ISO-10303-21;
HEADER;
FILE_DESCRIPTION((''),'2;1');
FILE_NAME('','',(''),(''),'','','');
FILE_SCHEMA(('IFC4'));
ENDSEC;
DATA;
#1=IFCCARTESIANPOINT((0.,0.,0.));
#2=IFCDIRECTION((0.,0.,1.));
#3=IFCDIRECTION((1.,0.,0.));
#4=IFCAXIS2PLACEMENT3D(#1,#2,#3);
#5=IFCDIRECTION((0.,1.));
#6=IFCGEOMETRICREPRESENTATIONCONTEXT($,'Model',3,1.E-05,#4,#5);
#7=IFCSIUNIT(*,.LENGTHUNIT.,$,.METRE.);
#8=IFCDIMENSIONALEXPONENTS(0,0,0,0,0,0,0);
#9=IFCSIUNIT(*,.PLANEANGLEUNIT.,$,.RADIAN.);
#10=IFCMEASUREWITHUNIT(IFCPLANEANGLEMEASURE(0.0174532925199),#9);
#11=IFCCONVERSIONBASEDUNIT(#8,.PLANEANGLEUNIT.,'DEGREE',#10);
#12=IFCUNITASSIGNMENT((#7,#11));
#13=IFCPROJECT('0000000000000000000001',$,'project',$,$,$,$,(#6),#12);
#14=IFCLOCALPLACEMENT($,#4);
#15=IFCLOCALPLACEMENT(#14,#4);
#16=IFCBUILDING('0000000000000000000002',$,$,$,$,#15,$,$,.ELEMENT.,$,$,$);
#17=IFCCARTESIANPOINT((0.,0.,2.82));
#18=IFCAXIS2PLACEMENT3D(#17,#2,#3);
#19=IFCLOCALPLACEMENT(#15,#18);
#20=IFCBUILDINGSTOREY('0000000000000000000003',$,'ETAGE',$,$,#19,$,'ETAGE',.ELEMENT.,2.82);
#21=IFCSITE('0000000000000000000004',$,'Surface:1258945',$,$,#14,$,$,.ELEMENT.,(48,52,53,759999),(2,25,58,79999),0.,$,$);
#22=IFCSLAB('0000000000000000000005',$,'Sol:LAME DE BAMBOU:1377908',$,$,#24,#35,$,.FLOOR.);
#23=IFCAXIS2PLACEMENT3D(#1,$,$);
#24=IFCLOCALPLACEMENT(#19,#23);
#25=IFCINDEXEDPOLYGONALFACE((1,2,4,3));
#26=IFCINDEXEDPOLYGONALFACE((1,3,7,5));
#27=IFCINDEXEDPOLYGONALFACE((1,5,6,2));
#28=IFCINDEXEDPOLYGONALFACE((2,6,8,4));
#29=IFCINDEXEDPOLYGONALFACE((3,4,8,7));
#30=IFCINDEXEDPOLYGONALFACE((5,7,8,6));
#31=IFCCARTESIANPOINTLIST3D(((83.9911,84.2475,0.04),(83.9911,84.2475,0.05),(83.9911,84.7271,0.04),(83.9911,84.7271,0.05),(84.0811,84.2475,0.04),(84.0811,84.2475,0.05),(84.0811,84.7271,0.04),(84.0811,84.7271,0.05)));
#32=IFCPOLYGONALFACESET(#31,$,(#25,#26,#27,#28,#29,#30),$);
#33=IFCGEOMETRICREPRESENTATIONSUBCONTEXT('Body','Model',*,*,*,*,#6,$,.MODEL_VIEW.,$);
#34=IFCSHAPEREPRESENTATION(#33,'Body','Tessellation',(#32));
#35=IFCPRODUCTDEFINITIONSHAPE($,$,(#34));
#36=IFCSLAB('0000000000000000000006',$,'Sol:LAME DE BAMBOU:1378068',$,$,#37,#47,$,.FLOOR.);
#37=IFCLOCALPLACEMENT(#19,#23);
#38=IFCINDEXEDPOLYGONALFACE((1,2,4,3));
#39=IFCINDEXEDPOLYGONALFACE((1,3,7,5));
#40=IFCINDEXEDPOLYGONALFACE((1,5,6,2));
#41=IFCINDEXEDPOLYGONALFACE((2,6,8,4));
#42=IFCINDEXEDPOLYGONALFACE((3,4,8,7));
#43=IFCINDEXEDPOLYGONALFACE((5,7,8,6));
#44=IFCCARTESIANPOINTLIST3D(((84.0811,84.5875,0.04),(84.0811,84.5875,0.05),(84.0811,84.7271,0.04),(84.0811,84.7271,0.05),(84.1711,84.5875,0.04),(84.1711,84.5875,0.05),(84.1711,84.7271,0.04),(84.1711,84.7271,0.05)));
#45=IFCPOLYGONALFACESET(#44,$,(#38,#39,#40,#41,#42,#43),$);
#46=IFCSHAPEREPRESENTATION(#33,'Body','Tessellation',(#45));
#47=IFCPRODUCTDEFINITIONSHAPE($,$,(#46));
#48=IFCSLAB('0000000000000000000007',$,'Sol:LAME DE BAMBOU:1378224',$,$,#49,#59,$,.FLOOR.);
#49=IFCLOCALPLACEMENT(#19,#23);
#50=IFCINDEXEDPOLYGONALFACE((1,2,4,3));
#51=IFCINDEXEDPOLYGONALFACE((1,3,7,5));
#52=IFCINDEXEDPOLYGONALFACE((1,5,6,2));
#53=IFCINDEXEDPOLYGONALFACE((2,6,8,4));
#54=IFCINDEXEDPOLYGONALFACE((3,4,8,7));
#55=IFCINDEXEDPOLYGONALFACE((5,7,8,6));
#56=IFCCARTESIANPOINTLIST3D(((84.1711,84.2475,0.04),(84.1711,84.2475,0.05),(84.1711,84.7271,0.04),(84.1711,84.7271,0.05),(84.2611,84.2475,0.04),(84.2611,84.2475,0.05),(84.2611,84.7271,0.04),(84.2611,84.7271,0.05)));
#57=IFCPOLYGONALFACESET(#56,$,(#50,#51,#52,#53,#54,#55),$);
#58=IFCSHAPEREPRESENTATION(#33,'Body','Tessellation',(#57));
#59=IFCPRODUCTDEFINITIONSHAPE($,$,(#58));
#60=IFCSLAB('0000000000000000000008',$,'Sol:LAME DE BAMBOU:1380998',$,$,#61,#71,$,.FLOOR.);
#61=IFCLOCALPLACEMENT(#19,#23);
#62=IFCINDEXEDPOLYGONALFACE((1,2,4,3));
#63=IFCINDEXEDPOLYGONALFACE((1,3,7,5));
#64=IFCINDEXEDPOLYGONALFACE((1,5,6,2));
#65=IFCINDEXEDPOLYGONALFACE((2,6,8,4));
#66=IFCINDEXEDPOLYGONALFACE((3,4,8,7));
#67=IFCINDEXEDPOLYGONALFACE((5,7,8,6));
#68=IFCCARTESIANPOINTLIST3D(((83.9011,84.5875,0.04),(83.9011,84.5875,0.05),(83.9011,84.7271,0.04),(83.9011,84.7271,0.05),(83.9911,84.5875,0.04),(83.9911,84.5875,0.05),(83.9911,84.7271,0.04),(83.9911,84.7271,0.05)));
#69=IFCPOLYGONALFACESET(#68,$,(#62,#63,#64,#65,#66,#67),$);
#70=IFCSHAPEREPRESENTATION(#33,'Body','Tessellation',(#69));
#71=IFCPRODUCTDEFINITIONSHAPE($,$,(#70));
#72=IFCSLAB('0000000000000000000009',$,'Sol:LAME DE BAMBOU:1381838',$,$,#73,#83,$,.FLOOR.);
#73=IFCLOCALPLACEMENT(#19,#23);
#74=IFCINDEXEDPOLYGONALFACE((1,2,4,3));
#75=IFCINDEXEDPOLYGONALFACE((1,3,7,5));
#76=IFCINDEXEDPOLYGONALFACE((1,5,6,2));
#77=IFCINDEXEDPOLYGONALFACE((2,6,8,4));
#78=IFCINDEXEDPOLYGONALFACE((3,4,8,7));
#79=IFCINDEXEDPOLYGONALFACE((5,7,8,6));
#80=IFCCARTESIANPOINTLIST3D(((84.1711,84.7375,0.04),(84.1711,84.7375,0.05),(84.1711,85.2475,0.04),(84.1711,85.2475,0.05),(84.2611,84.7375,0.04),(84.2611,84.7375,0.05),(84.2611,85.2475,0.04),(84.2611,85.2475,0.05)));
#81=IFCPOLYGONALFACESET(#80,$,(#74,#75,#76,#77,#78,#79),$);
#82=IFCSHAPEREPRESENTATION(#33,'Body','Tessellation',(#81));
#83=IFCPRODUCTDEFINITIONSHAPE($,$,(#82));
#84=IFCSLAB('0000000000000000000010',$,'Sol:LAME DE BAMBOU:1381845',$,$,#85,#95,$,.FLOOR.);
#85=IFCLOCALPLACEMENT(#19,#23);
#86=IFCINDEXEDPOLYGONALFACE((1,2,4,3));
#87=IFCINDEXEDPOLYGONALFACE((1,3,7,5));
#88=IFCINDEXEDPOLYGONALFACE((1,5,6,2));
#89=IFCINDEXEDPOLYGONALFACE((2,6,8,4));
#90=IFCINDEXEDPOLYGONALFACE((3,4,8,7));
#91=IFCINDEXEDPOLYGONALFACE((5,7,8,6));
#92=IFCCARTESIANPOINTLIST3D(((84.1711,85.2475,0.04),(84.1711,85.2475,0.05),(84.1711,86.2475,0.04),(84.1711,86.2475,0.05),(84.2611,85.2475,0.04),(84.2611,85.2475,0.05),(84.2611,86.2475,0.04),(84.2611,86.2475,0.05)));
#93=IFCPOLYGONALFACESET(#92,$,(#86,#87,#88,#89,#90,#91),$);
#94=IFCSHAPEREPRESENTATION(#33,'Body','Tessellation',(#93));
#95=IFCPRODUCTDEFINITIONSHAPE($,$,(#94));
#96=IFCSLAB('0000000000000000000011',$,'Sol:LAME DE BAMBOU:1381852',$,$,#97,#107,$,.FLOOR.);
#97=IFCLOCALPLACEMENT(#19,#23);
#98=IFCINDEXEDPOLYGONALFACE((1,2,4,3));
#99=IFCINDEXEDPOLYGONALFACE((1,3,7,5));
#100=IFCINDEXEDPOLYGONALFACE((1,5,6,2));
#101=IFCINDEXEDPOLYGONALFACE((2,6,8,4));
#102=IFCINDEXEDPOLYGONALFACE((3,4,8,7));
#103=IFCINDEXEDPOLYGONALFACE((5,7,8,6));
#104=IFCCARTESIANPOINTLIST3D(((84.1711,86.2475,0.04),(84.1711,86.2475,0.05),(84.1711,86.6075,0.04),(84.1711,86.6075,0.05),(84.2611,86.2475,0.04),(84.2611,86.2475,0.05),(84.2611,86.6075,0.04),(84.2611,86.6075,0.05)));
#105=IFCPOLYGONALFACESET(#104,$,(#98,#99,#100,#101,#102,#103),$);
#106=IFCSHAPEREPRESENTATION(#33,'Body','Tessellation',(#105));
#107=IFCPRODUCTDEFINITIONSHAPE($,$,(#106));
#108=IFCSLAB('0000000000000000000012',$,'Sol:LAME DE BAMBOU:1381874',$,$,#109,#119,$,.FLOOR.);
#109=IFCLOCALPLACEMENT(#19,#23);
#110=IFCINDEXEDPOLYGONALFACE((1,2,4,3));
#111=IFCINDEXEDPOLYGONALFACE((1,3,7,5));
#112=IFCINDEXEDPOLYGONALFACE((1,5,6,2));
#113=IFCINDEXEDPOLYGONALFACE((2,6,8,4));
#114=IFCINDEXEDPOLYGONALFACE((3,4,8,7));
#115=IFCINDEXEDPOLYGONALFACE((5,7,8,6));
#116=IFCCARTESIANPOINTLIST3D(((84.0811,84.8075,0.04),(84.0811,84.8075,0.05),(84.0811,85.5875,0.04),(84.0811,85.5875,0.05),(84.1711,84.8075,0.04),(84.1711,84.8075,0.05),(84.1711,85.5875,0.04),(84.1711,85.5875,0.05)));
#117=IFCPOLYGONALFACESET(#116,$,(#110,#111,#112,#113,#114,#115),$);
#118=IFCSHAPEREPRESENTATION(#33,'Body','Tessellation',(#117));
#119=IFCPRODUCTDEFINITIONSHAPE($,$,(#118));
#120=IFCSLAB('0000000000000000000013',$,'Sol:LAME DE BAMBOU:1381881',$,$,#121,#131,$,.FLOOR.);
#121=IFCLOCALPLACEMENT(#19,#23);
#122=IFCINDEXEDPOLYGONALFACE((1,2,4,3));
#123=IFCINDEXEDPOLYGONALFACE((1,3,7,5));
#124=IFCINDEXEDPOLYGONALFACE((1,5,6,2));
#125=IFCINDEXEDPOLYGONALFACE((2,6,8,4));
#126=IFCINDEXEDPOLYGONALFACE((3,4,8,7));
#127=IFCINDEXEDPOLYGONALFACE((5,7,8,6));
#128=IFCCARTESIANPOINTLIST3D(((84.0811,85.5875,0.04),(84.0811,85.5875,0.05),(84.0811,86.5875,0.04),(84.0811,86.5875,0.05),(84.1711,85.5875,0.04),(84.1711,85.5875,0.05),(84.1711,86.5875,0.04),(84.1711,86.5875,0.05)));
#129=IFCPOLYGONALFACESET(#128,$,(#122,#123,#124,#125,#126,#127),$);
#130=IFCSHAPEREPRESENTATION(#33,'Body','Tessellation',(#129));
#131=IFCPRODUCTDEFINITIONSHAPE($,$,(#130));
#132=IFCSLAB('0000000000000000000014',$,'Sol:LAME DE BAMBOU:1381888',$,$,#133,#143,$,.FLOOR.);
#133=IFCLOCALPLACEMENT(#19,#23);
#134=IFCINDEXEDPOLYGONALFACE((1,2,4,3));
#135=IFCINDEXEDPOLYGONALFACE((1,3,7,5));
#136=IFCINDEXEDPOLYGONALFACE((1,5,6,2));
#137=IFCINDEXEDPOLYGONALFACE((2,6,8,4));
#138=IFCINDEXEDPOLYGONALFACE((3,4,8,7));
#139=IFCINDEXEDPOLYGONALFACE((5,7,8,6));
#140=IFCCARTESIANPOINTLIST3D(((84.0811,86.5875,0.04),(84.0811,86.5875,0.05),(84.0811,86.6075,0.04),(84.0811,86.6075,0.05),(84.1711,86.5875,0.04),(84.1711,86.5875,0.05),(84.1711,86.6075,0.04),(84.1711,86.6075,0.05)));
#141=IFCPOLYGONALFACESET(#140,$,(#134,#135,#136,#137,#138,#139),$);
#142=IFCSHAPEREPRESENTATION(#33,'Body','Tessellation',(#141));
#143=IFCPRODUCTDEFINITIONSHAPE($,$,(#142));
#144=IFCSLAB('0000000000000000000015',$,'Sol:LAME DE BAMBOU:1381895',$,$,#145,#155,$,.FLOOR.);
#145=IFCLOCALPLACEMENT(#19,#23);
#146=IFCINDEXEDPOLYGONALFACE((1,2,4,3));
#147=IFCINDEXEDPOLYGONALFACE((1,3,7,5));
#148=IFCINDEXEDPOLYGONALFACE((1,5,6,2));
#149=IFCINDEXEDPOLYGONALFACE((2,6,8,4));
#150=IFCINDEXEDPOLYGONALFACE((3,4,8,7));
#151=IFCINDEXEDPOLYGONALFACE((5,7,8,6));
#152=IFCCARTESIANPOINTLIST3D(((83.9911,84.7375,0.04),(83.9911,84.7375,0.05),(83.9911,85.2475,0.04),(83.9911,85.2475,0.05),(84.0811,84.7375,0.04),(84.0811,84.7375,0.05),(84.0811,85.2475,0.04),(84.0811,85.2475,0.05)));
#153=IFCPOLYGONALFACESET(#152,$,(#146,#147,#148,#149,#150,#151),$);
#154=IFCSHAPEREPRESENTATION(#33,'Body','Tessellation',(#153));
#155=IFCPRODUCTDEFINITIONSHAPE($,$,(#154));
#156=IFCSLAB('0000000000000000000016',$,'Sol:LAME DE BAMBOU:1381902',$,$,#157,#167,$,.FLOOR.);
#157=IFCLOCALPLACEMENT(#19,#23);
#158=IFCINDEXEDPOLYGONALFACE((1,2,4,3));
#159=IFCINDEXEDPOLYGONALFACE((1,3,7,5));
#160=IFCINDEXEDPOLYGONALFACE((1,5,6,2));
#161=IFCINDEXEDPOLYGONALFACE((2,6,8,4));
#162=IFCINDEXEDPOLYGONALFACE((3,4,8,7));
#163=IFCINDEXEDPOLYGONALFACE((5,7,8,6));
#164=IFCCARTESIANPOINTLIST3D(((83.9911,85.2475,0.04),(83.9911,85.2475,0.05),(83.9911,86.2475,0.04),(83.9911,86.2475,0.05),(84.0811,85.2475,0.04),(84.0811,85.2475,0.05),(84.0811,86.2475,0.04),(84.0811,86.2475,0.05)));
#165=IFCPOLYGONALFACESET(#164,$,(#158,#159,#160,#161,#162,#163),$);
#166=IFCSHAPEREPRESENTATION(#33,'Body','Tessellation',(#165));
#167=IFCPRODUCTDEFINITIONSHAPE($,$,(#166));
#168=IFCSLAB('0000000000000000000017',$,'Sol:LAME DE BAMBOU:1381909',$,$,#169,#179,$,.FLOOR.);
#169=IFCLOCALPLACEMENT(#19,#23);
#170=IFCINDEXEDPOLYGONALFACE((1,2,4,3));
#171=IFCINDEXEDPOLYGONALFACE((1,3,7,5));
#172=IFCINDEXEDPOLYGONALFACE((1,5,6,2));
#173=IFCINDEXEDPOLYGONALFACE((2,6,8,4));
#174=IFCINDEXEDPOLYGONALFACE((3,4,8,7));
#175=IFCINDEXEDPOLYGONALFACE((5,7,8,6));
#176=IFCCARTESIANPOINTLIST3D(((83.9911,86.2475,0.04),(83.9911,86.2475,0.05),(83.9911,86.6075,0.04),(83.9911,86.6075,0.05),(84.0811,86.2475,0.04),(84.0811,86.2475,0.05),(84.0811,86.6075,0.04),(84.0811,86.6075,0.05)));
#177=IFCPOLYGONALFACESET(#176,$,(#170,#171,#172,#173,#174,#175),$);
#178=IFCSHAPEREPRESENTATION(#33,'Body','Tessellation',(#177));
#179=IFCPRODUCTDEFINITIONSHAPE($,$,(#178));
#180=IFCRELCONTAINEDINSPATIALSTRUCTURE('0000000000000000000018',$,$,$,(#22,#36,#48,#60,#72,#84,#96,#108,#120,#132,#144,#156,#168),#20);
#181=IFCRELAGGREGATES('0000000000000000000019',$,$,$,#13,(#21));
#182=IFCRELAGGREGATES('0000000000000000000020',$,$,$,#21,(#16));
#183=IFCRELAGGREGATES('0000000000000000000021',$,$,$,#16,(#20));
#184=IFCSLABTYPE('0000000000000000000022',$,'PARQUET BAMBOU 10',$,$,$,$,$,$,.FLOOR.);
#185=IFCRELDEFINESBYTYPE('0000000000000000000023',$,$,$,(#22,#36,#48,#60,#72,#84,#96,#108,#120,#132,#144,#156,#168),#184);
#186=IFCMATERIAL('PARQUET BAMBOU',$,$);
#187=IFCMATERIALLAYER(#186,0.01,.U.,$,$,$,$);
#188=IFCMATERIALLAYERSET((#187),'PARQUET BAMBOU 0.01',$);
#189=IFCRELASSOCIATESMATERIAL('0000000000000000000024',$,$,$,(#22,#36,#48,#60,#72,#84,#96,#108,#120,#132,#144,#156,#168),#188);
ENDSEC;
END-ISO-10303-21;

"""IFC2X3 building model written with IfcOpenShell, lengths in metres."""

from ifc_helpers import new_model, entity, si_unit, converted_unit, direction, frame, origin_with_axes, place, context, subcontext, project, spatial, polyline, outline, extrude, material, layer, layer_set, layer_usage, type_object, element, save


model = new_model("IFC2X3")

# Units and contexts
model_context = context("Model", 3, precision=1e-05, world=origin_with_axes(), true_north=direction((0.0, 1.0)))
body_context = subcontext(model_context, "Body", "Model", "MODEL_VIEW")
ifc_project = project(units=[si_unit("LENGTHUNIT", "METRE"), converted_unit("PLANEANGLEUNIT", "DEGREE", entity("IfcPlaneAngleMeasure", 0.0174532925199), si_unit("PLANEANGLEUNIT", "RADIAN"), dimensions=[0, 0, 0, 0, 0, 0, 0])], contexts=[model_context])

# Site, building, storey
site_placement = place(None, origin_with_axes())
site = spatial("IfcSite", under=ifc_project, at=site_placement, Name="Surface:1258945", CompositionType="ELEMENT", RefLatitude=(48, 52, 53, 759999), RefLongitude=(2, 25, 58, 79999), RefElevation=0.0)
building_placement = place(site_placement, origin_with_axes())
building = spatial("IfcBuilding", under=site, at=building_placement, CompositionType="ELEMENT")
storey_placement = place(building_placement, frame((0.0, 0.0, 2.82), z_axis=(0.0, 0.0, 1.0), x_axis=(1.0, 0.0, 0.0)))
storey = spatial("IfcBuildingStorey", under=building, at=storey_placement, Name="ETAGE", LongName="ETAGE", CompositionType="ELEMENT", Elevation=2.82)

# Slabs
ifc_material_1 = material(Name="PARQUET BAMBOU")
ifc_layer_1 = layer(ifc_material_1, 0.01, ventilated="UNKNOWN")
ifc_layer_set_1 = layer_set([ifc_layer_1], Name="PARQUET BAMBOU 0.01")
ifc_layer_usage_1 = layer_usage(ifc_layer_set_1, "AXIS3", "NEGATIVE", 0.01)
slab_type = type_object("IfcSlabType", Name="PARQUET BAMBOU 10", PredefinedType="FLOOR")
slab_1_placement = place(storey_placement, frame((83.9911, 84.7271, 0.05), z_axis=(0.0, 0.0, 1.0), x_axis=(1.0, 0.0, 0.0)))
element("IfcSlab", 1, at=slab_1_placement, inside=storey, type_object=slab_type, material=ifc_layer_usage_1, Name="Sol:LAME DE BAMBOU:1377908", PredefinedType="FLOOR", context=body_context, shape_type="SweptSolid", body=[
    extrude(outline(polyline([(0.0, 0.0), (0.0, -0.4796), (0.09, -0.4796), (0.09, 0.0), (0.0, 0.0)])), frame((0.0, 0.0, -0.01), z_axis=(0.0, 0.0, 1.0), x_axis=(1.0, 0.0, 0.0)), (0.0, 0.0, 1.0), 0.01),
])
ifc_layer_usage_2 = layer_usage(ifc_layer_set_1, "AXIS3", "NEGATIVE", 0.01)
slab_2_placement = place(storey_placement, frame((84.0811, 84.7271, 0.05), z_axis=(0.0, 0.0, 1.0), x_axis=(1.0, 0.0, 0.0)))
element("IfcSlab", 2, at=slab_2_placement, inside=storey, type_object=slab_type, material=ifc_layer_usage_2, Name="Sol:LAME DE BAMBOU:1378068", PredefinedType="FLOOR", context=body_context, shape_type="SweptSolid", body=[
    extrude(outline(polyline([(0.0, 0.0), (0.0, -0.1396), (0.09, -0.1396), (0.09, 0.0), (0.0, 0.0)])), frame((0.0, 0.0, -0.01), z_axis=(0.0, 0.0, 1.0), x_axis=(1.0, 0.0, 0.0)), (0.0, 0.0, 1.0), 0.01),
])
ifc_layer_usage_3 = layer_usage(ifc_layer_set_1, "AXIS3", "NEGATIVE", 0.01)
slab_3_placement = place(storey_placement, frame((84.1711, 84.7271, 0.05), z_axis=(0.0, 0.0, 1.0), x_axis=(1.0, 0.0, 0.0)))
element("IfcSlab", 3, at=slab_3_placement, inside=storey, type_object=slab_type, material=ifc_layer_usage_3, Name="Sol:LAME DE BAMBOU:1378224", PredefinedType="FLOOR", context=body_context, shape_type="SweptSolid", body=[
    extrude(outline(polyline([(0.0, 0.0), (0.0, -0.4796), (0.09, -0.4796), (0.09, 0.0), (0.0, 0.0)])), frame((0.0, 0.0, -0.01), z_axis=(0.0, 0.0, 1.0), x_axis=(1.0, 0.0, 0.0)), (0.0, 0.0, 1.0), 0.01),
])
ifc_layer_usage_4 = layer_usage(ifc_layer_set_1, "AXIS3", "NEGATIVE", 0.01)
slab_4_placement = place(storey_placement, frame((83.9011, 84.7271, 0.05), z_axis=(0.0, 0.0, 1.0), x_axis=(1.0, 0.0, 0.0)))
element("IfcSlab", 4, at=slab_4_placement, inside=storey, type_object=slab_type, material=ifc_layer_usage_4, Name="Sol:LAME DE BAMBOU:1380998", PredefinedType="FLOOR", context=body_context, shape_type="SweptSolid", body=[
    extrude(outline(polyline([(0.0, 0.0), (0.0, -0.1396), (0.09, -0.1396), (0.09, 0.0), (0.0, 0.0)])), frame((0.0, 0.0, -0.01), z_axis=(0.0, 0.0, 1.0), x_axis=(1.0, 0.0, 0.0)), (0.0, 0.0, 1.0), 0.01),
])
ifc_layer_usage_5 = layer_usage(ifc_layer_set_1, "AXIS3", "NEGATIVE", 0.01)
slab_5_placement = place(storey_placement, frame((84.1711, 85.2475, 0.05), z_axis=(0.0, 0.0, 1.0), x_axis=(1.0, 0.0, 0.0)))
element("IfcSlab", 5, at=slab_5_placement, inside=storey, type_object=slab_type, material=ifc_layer_usage_5, Name="Sol:LAME DE BAMBOU:1381838", PredefinedType="FLOOR", context=body_context, shape_type="SweptSolid", body=[
    extrude(outline(polyline([(0.0, 0.0), (0.0, -0.51), (0.09, -0.51), (0.09, 0.0), (0.0, 0.0)])), frame((0.0, 0.0, -0.01), z_axis=(0.0, 0.0, 1.0), x_axis=(1.0, 0.0, 0.0)), (0.0, 0.0, 1.0), 0.01),
])
ifc_layer_usage_6 = layer_usage(ifc_layer_set_1, "AXIS3", "NEGATIVE", 0.01)
slab_6_placement = place(storey_placement, frame((84.1711, 86.2475, 0.05), z_axis=(0.0, 0.0, 1.0), x_axis=(1.0, 0.0, 0.0)))
element("IfcSlab", 6, at=slab_6_placement, inside=storey, type_object=slab_type, material=ifc_layer_usage_6, Name="Sol:LAME DE BAMBOU:1381845", PredefinedType="FLOOR", context=body_context, shape_type="SweptSolid", body=[
    extrude(outline(polyline([(0.0, 0.0), (0.0, -1.0), (0.09, -1.0), (0.09, 0.0), (0.0, 0.0)])), frame((0.0, 0.0, -0.01), z_axis=(0.0, 0.0, 1.0), x_axis=(1.0, 0.0, 0.0)), (0.0, 0.0, 1.0), 0.01),
])
ifc_layer_usage_7 = layer_usage(ifc_layer_set_1, "AXIS3", "NEGATIVE", 0.01)
slab_7_placement = place(storey_placement, frame((84.1711, 86.6075, 0.05), z_axis=(0.0, 0.0, 1.0), x_axis=(1.0, 0.0, 0.0)))
element("IfcSlab", 7, at=slab_7_placement, inside=storey, type_object=slab_type, material=ifc_layer_usage_7, Name="Sol:LAME DE BAMBOU:1381852", PredefinedType="FLOOR", context=body_context, shape_type="SweptSolid", body=[
    extrude(outline(polyline([(0.0, 0.0), (0.0, -0.36), (0.09, -0.36), (0.09, 0.0), (0.0, 0.0)])), frame((0.0, 0.0, -0.01), z_axis=(0.0, 0.0, 1.0), x_axis=(1.0, 0.0, 0.0)), (0.0, 0.0, 1.0), 0.01),
])
ifc_layer_usage_8 = layer_usage(ifc_layer_set_1, "AXIS3", "NEGATIVE", 0.01)
slab_8_placement = place(storey_placement, frame((84.0811, 85.5875, 0.05), z_axis=(0.0, 0.0, 1.0), x_axis=(1.0, 0.0, 0.0)))
element("IfcSlab", 8, at=slab_8_placement, inside=storey, type_object=slab_type, material=ifc_layer_usage_8, Name="Sol:LAME DE BAMBOU:1381874", PredefinedType="FLOOR", context=body_context, shape_type="SweptSolid", body=[
    extrude(outline(polyline([(0.0, 0.0), (0.0, -0.78), (0.09, -0.78), (0.09, 0.0), (0.0, 0.0)])), frame((0.0, 0.0, -0.01), z_axis=(0.0, 0.0, 1.0), x_axis=(1.0, 0.0, 0.0)), (0.0, 0.0, 1.0), 0.01),
])
ifc_layer_usage_9 = layer_usage(ifc_layer_set_1, "AXIS3", "NEGATIVE", 0.01)
slab_9_placement = place(storey_placement, frame((84.0811, 86.5875, 0.05), z_axis=(0.0, 0.0, 1.0), x_axis=(1.0, 0.0, 0.0)))
element("IfcSlab", 9, at=slab_9_placement, inside=storey, type_object=slab_type, material=ifc_layer_usage_9, Name="Sol:LAME DE BAMBOU:1381881", PredefinedType="FLOOR", context=body_context, shape_type="SweptSolid", body=[
    extrude(outline(polyline([(0.0, 0.0), (0.0, -1.0), (0.09, -1.0), (0.09, 0.0), (0.0, 0.0)])), frame((0.0, 0.0, -0.01), z_axis=(0.0, 0.0, 1.0), x_axis=(1.0, 0.0, 0.0)), (0.0, 0.0, 1.0), 0.01),
])
ifc_layer_usage_10 = layer_usage(ifc_layer_set_1, "AXIS3", "NEGATIVE", 0.01)
slab_10_placement = place(storey_placement, frame((84.0811, 86.6075, 0.05), z_axis=(0.0, 0.0, 1.0), x_axis=(1.0, 0.0, 0.0)))
element("IfcSlab", 10, at=slab_10_placement, inside=storey, type_object=slab_type, material=ifc_layer_usage_10, Name="Sol:LAME DE BAMBOU:1381888", PredefinedType="FLOOR", context=body_context, shape_type="SweptSolid", body=[
    extrude(outline(polyline([(0.0, 0.0), (0.0, -0.02), (0.09, -0.02), (0.09, 0.0), (0.0, 0.0)])), frame((0.0, 0.0, -0.01), z_axis=(0.0, 0.0, 1.0), x_axis=(1.0, 0.0, 0.0)), (0.0, 0.0, 1.0), 0.01),
])
ifc_layer_usage_11 = layer_usage(ifc_layer_set_1, "AXIS3", "NEGATIVE", 0.01)
slab_11_placement = place(storey_placement, frame((83.9911, 85.2475, 0.05), z_axis=(0.0, 0.0, 1.0), x_axis=(1.0, 0.0, 0.0)))
element("IfcSlab", 11, at=slab_11_placement, inside=storey, type_object=slab_type, material=ifc_layer_usage_11, Name="Sol:LAME DE BAMBOU:1381895", PredefinedType="FLOOR", context=body_context, shape_type="SweptSolid", body=[
    extrude(outline(polyline([(0.0, 0.0), (0.0, -0.51), (0.09, -0.51), (0.09, 0.0), (0.0, 0.0)])), frame((0.0, 0.0, -0.01), z_axis=(0.0, 0.0, 1.0), x_axis=(1.0, 0.0, 0.0)), (0.0, 0.0, 1.0), 0.01),
])
ifc_layer_usage_12 = layer_usage(ifc_layer_set_1, "AXIS3", "NEGATIVE", 0.01)
slab_12_placement = place(storey_placement, frame((83.9911, 86.2475, 0.05), z_axis=(0.0, 0.0, 1.0), x_axis=(1.0, 0.0, 0.0)))
element("IfcSlab", 12, at=slab_12_placement, inside=storey, type_object=slab_type, material=ifc_layer_usage_12, Name="Sol:LAME DE BAMBOU:1381902", PredefinedType="FLOOR", context=body_context, shape_type="SweptSolid", body=[
    extrude(outline(polyline([(0.0, 0.0), (0.0, -1.0), (0.09, -1.0), (0.09, 0.0), (0.0, 0.0)])), frame((0.0, 0.0, -0.01), z_axis=(0.0, 0.0, 1.0), x_axis=(1.0, 0.0, 0.0)), (0.0, 0.0, 1.0), 0.01),
])
ifc_layer_usage_13 = layer_usage(ifc_layer_set_1, "AXIS3", "NEGATIVE", 0.01)
slab_13_placement = place(storey_placement, frame((83.9911, 86.6075, 0.05), z_axis=(0.0, 0.0, 1.0), x_axis=(1.0, 0.0, 0.0)))
element("IfcSlab", 13, at=slab_13_placement, inside=storey, type_object=slab_type, material=ifc_layer_usage_13, Name="Sol:LAME DE BAMBOU:1381909", PredefinedType="FLOOR", context=body_context, shape_type="SweptSolid", body=[
    extrude(outline(polyline([(0.0, 0.0), (0.0, -0.36), (0.09, -0.36), (0.09, 0.0), (0.0, 0.0)])), frame((0.0, 0.0, -0.01), z_axis=(0.0, 0.0, 1.0), x_axis=(1.0, 0.0, 0.0)), (0.0, 0.0, 1.0), 0.01),
])

save(model, "model.ifc")
